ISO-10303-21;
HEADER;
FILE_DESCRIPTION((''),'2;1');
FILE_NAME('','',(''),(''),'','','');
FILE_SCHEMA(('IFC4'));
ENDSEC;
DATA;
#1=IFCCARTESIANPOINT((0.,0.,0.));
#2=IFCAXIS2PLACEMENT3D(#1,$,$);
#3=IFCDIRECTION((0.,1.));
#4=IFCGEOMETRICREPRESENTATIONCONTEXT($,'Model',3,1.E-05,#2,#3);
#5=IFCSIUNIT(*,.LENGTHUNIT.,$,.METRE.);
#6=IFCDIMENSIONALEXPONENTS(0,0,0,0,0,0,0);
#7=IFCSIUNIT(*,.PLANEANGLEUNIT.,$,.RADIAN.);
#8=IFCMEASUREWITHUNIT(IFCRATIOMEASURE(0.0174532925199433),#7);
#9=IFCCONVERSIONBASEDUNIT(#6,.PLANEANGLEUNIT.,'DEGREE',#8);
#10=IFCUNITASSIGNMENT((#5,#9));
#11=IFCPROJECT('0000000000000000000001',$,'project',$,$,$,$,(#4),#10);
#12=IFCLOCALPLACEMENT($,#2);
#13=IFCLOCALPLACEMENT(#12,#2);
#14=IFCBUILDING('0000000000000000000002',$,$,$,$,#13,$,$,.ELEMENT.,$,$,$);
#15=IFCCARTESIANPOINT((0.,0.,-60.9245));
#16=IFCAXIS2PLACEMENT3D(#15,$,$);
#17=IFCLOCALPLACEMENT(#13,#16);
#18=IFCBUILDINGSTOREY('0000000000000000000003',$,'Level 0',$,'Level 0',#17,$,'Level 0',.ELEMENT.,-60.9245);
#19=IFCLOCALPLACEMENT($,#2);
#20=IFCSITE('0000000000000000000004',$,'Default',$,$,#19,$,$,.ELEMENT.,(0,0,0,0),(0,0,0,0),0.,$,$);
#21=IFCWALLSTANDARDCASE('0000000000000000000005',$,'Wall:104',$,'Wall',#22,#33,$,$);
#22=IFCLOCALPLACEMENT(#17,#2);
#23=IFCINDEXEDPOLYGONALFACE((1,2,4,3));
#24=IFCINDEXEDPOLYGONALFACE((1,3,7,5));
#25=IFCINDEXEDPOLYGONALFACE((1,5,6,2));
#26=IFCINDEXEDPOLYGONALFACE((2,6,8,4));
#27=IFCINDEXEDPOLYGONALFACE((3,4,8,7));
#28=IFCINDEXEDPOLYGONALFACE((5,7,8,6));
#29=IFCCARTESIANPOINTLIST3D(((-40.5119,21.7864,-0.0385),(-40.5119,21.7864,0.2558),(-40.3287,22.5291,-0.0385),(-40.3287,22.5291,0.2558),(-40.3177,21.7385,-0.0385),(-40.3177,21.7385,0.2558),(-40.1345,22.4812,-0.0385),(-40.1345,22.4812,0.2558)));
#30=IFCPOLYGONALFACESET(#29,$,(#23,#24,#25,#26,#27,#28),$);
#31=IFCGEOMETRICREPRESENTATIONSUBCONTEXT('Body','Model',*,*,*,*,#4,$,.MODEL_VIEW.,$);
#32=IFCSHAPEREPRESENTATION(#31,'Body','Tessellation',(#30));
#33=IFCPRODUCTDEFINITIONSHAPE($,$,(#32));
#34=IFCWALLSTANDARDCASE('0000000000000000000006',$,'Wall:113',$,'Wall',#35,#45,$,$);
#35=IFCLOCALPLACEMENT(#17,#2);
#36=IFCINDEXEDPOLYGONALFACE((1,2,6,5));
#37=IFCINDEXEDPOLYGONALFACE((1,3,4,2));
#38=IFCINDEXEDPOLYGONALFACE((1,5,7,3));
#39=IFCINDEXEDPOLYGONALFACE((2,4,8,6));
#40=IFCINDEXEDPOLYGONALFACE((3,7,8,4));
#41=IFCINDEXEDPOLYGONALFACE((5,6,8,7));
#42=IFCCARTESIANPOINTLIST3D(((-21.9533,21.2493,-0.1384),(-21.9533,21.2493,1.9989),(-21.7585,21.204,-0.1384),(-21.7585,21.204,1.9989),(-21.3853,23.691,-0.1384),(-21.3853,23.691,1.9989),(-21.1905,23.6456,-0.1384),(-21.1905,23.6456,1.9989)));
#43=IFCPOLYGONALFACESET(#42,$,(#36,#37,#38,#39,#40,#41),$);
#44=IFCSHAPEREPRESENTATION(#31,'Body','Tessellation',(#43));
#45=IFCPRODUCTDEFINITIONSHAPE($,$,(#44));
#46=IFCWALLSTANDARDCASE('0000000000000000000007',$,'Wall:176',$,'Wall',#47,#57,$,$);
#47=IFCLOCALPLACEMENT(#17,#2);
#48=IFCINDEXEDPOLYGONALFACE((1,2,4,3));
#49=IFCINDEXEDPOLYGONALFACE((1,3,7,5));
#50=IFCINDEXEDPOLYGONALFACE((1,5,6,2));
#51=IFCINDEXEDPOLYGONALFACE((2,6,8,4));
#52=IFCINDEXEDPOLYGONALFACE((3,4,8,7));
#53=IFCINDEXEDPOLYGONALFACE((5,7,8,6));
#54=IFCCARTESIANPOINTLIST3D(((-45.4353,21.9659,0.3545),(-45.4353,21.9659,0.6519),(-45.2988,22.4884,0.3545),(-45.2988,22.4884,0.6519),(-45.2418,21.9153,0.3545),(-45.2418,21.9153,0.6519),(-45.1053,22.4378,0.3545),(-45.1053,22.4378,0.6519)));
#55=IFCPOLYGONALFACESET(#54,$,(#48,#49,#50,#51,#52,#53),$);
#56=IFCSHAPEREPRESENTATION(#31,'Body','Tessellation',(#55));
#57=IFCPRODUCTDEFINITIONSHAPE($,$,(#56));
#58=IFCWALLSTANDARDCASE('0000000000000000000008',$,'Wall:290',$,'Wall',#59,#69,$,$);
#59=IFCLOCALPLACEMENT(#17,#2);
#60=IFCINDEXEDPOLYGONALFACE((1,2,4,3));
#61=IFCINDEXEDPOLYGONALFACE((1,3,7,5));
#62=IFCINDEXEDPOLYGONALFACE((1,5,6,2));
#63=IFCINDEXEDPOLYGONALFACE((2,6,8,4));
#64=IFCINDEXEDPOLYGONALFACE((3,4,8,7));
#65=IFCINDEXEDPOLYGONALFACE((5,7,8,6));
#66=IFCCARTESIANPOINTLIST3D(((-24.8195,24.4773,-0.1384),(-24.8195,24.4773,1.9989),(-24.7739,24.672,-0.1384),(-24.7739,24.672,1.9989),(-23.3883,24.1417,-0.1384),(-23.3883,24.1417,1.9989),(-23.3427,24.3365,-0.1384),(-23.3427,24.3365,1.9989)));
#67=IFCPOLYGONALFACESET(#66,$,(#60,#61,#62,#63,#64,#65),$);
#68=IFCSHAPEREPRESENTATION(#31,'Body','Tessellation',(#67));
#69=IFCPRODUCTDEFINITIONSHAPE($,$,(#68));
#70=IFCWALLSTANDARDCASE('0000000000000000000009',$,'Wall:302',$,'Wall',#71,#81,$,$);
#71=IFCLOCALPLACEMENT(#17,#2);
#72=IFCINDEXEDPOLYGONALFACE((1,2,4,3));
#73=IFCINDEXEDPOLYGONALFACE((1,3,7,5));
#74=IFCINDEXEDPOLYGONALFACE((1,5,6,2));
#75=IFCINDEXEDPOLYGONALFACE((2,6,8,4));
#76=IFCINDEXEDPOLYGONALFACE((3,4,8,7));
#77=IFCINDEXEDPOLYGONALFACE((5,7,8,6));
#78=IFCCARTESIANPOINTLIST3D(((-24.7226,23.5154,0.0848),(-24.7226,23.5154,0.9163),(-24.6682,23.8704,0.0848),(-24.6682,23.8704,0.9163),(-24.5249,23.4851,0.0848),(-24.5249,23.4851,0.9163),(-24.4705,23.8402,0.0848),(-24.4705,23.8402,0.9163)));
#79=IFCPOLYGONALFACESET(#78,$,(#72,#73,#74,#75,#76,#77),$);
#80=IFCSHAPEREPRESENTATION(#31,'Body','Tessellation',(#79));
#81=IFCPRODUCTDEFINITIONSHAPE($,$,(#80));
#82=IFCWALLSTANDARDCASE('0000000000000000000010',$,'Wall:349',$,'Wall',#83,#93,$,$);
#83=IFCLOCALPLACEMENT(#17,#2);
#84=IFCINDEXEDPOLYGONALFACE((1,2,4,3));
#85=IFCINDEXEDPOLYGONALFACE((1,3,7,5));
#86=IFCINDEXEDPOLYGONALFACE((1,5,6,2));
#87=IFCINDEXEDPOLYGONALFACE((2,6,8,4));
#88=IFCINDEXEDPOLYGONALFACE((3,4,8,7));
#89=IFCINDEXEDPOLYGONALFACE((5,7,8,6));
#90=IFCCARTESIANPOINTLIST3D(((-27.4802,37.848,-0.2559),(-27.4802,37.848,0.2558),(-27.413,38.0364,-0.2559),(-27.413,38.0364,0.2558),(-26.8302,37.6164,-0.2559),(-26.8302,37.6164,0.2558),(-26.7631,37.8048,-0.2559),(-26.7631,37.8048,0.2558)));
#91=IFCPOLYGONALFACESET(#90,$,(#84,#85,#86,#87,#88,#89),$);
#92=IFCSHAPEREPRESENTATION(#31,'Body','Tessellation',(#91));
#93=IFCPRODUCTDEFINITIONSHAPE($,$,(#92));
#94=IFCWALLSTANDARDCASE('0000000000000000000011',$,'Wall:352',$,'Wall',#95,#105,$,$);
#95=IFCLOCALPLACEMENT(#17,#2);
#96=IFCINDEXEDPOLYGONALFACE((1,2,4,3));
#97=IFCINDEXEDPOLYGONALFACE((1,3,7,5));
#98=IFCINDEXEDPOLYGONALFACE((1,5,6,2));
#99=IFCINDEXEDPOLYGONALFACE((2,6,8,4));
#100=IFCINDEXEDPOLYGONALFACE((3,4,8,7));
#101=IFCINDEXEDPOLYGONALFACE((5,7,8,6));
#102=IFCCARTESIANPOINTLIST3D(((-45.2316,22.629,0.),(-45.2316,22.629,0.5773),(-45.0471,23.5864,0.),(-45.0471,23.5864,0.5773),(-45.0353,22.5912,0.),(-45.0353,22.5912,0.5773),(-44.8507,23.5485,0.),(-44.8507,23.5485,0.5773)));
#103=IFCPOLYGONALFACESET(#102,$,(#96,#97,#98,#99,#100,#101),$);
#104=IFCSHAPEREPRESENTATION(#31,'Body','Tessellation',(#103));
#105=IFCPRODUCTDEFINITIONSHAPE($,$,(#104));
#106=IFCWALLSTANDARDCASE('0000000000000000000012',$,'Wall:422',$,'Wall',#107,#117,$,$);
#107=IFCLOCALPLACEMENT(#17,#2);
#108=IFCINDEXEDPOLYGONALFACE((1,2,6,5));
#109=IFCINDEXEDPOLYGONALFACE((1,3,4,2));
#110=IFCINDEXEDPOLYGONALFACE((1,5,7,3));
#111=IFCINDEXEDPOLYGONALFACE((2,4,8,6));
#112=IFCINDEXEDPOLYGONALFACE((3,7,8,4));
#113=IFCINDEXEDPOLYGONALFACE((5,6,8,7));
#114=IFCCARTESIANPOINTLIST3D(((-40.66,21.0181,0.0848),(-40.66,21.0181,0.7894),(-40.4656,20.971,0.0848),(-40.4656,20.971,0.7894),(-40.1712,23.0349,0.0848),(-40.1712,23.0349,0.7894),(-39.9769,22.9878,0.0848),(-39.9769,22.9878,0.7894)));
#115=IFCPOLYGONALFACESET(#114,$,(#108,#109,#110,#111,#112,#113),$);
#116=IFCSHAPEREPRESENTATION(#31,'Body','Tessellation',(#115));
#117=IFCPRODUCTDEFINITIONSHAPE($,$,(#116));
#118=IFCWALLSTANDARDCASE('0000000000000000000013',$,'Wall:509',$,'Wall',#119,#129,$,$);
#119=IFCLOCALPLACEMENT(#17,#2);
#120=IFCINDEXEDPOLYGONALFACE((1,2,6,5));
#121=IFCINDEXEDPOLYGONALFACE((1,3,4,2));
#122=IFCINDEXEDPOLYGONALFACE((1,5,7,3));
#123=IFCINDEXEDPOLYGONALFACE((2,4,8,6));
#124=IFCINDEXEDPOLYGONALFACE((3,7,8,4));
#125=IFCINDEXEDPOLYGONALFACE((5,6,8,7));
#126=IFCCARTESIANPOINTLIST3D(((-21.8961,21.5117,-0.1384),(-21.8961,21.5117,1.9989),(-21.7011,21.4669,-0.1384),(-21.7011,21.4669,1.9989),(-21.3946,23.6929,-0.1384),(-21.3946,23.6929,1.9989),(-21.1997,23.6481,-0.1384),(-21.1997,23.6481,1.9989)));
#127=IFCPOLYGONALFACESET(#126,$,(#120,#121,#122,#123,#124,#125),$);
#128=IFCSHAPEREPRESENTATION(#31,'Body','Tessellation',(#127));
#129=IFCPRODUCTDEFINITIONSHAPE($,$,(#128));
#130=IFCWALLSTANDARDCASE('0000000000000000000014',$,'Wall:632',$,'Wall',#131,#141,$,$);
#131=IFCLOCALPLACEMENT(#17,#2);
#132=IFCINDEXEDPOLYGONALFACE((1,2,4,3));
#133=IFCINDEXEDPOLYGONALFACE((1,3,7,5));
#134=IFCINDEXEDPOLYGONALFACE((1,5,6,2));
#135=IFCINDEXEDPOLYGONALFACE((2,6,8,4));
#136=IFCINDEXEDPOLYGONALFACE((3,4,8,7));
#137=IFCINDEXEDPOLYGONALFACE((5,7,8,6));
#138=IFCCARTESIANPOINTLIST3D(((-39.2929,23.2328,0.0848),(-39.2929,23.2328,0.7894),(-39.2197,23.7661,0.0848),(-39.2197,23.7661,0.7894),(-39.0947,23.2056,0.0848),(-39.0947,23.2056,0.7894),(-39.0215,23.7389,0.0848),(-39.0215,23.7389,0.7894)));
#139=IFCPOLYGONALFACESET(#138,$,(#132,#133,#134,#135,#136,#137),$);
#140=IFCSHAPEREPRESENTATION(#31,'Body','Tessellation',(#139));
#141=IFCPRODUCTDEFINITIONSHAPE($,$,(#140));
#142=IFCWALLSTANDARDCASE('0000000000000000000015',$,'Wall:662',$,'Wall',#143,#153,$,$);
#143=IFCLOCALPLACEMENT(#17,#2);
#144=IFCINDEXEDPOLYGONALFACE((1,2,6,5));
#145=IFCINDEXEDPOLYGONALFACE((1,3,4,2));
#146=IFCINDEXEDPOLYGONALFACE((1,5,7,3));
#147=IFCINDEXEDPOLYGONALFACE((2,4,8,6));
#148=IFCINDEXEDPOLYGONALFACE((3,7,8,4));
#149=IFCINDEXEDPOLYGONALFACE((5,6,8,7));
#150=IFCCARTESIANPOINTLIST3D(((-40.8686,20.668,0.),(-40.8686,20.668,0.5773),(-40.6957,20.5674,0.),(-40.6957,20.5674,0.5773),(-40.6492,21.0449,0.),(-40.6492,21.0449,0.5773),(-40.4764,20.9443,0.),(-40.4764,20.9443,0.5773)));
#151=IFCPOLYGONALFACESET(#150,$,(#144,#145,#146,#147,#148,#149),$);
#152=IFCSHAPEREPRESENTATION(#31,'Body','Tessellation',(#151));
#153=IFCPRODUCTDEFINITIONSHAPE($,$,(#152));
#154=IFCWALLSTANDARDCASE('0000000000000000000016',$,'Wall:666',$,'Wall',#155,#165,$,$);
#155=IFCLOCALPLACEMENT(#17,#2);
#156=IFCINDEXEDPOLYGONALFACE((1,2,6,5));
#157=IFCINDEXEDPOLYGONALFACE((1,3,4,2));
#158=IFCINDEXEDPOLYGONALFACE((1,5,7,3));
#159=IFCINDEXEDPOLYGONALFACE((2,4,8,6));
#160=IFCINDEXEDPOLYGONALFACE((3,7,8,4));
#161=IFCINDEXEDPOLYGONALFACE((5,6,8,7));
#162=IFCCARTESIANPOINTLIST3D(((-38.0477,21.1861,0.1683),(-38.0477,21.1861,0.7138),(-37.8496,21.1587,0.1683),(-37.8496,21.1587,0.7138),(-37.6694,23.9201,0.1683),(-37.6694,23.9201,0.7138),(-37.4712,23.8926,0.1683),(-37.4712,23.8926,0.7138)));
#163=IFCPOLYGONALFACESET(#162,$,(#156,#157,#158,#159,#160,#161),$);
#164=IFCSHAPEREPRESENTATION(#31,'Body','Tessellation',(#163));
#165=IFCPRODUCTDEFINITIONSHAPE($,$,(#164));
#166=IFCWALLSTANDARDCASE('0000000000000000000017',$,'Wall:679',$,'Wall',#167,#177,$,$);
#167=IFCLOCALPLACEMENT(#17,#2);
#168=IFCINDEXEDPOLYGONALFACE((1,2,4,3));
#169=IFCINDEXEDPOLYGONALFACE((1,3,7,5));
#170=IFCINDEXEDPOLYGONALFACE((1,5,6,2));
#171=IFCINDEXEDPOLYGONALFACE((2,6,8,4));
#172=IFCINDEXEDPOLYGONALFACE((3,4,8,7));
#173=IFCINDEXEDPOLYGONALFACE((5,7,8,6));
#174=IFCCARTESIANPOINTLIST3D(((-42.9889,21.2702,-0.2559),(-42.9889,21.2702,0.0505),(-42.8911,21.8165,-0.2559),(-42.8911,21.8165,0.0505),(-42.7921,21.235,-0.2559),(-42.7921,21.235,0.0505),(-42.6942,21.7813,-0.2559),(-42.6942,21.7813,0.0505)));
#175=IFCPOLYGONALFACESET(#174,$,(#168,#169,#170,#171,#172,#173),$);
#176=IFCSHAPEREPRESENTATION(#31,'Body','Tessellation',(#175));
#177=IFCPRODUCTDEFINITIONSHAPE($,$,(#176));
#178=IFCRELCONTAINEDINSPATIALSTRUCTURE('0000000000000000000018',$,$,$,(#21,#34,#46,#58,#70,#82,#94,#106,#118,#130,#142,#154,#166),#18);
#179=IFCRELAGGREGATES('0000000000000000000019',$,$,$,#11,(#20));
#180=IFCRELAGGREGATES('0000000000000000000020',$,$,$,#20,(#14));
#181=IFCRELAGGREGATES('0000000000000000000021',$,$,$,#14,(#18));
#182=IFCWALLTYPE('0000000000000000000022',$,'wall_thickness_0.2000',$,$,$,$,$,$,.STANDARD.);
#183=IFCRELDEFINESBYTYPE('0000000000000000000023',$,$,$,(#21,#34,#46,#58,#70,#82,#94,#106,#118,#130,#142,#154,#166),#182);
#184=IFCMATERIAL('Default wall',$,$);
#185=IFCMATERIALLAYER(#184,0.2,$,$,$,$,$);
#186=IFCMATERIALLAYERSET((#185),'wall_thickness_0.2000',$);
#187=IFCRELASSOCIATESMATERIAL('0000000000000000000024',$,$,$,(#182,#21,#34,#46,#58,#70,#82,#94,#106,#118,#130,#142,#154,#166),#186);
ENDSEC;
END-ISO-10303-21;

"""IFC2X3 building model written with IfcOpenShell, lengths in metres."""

from ifc_helpers import new_model, entity, si_unit, converted_unit, direction, frame, origin, place, context, subcontext, project, spatial, polyline, outline, extrude, material, layer, layer_set, layer_usage, type_object, element, save


model = new_model("IFC2X3")

# Units and contexts
model_context = context("Model", 3, precision=1e-05, world=origin(), true_north=direction((0.0, 1.0)))
body_context = subcontext(model_context, "Body", "Model", "MODEL_VIEW")
ifc_project = project(units=[si_unit("LENGTHUNIT", "METRE"), converted_unit("PLANEANGLEUNIT", "DEGREE", entity("IfcRatioMeasure", 0.0174532925199433), si_unit("PLANEANGLEUNIT", "RADIAN"), dimensions=[0, 0, 0, 0, 0, 0, 0])], contexts=[model_context])

# Site, building, storey
site_placement = place(None, origin())
site = spatial("IfcSite", under=ifc_project, at=site_placement, Name="Default", CompositionType="ELEMENT", RefLatitude=(0, 0, 0, 0), RefLongitude=(0, 0, 0, 0), RefElevation=0.0)
placement_1 = place(None, origin())
building_placement = place(placement_1, origin())
building = spatial("IfcBuilding", under=site, at=building_placement, CompositionType="ELEMENT")
storey_placement = place(building_placement, frame((0.0, 0.0, -60.9245)))
storey = spatial("IfcBuildingStorey", under=building, at=storey_placement, Name="Level 0", ObjectType="Level 0", LongName="Level 0", CompositionType="ELEMENT", Elevation=-60.9245)

# Walls
ifc_material = material(Name="Default wall")
ifc_layer = layer(ifc_material, 0.2)
ifc_layer_set = layer_set([ifc_layer], Name="wall_thickness_0.2000")
ifc_layer_usage = layer_usage(ifc_layer_set, "AXIS2", "POSITIVE", -0.1)
wall_type = type_object("IfcWallType", Name="wall_thickness_0.2000", PredefinedType="STANDARD", material=ifc_layer_set)
placement_2 = place(building_placement, frame((0.0, 0.0, -60.963)))
wall_1_placement = place(placement_2, frame((-40.4148, 21.7624, 0.0), z_axis=(0.0, 0.0, 1.0), x_axis=(0.239508, 0.970894, 0.0)))
element("IfcWallStandardCase", 1, at=wall_1_placement, inside=storey, type_object=wall_type, material=ifc_layer_usage, Name="Wall:104", ObjectType="Wall", context=body_context, shape_type="SweptSolid", body=[
    extrude(outline(polyline([(0.765, -0.1), (0.765, 0.1), (0.0, 0.1), (0.0, -0.1), (0.765, -0.1)])), origin(), (0.0, 0.0, 1.0), 0.2943),
])
placement_3 = place(building_placement, frame((0.0, 0.0, -61.0629)))
wall_2_placement = place(placement_3, frame((-21.2879, 23.6683, 0.0), z_axis=(0.0, 0.0, 1.0), x_axis=(-0.226591, -0.97399, 0.0)))
element("IfcWallStandardCase", 2, at=wall_2_placement, inside=storey, type_object=wall_type, material=ifc_layer_usage, Name="Wall:113", ObjectType="Wall", context=body_context, shape_type="SweptSolid", body=[
    extrude(outline(polyline([(2.5069, -0.1), (2.5069, 0.1), (0.0, 0.1), (0.0, -0.1), (2.5069, -0.1)])), origin(), (0.0, 0.0, 1.0), 2.1372),
])
placement_4 = place(building_placement, frame((0.0, 0.0, -60.57)))
wall_3_placement = place(placement_4, frame((-45.3385, 21.9406, 0.0), z_axis=(0.0, 0.0, 1.0), x_axis=(0.252802, 0.967518, 0.0)))
element("IfcWallStandardCase", 3, at=wall_3_placement, inside=storey, type_object=wall_type, material=ifc_layer_usage, Name="Wall:176", ObjectType="Wall", context=body_context, shape_type="SweptSolid", body=[
    extrude(outline(polyline([(0.54, -0.1), (0.54, 0.1), (0.0, 0.1), (0.0, -0.1), (0.54, -0.1)])), origin(), (0.0, 0.0, 1.0), 0.2973),
])
placement_5 = place(building_placement, frame((0.0, 0.0, -61.0629)))
wall_4_placement = place(placement_5, frame((-23.3655, 24.2391, 0.0), z_axis=(0.0, 0.0, 1.0), x_axis=(-0.973602, 0.228252, 0.0)))
element("IfcWallStandardCase", 4, at=wall_4_placement, inside=storey, type_object=wall_type, material=ifc_layer_usage, Name="Wall:290", ObjectType="Wall", context=body_context, shape_type="SweptSolid", body=[
    extrude(outline(polyline([(1.47, -0.1), (1.47, 0.1), (0.0, 0.1), (0.0, -0.1), (1.47, -0.1)])), origin(), (0.0, 0.0, 1.0), 2.1372),
])
placement_6 = place(building_placement, frame((0.0, 0.0, -60.8397)))
wall_5_placement = place(placement_6, frame((-24.5694, 23.8553, 0.0), z_axis=(0.0, 0.0, 1.0), x_axis=(-0.151291, -0.988489, 0.0)))
element("IfcWallStandardCase", 5, at=wall_5_placement, inside=storey, type_object=wall_type, material=ifc_layer_usage, Name="Wall:302", ObjectType="Wall", context=body_context, shape_type="SweptSolid", body=[
    extrude(outline(polyline([(0.3592, -0.1), (0.3592, 0.1), (0.0, 0.1), (0.0, -0.1), (0.3592, -0.1)])), origin(), (0.0, 0.0, 1.0), 0.8315),
])
placement_7 = place(building_placement, frame((0.0, 0.0, -61.1804)))
wall_6_placement = place(placement_7, frame((-27.4466, 37.9422, 0.0), z_axis=(0.0, 0.0, 1.0), x_axis=(0.941944, -0.335771, 0.0)))
element("IfcWallStandardCase", 6, at=wall_6_placement, inside=storey, type_object=wall_type, material=ifc_layer_usage, Name="Wall:349", ObjectType="Wall", context=body_context, shape_type="SweptSolid", body=[
    extrude(outline(polyline([(0.69, -0.1), (0.69, 0.1), (0.0, 0.1), (0.0, -0.1), (0.69, -0.1)])), origin(), (0.0, 0.0, 1.0), 0.5117),
])
wall_7_placement = place(storey_placement, frame((-44.9489, 23.5675, 0.0), z_axis=(0.0, 0.0, 1.0), x_axis=(-0.189256, -0.981928, 0.0)))
element("IfcWallStandardCase", 7, at=wall_7_placement, inside=storey, type_object=wall_type, material=ifc_layer_usage, Name="Wall:352", ObjectType="Wall", context=body_context, shape_type="SweptSolid", body=[
    extrude(outline(polyline([(0.975, -0.1), (0.975, 0.1), (0.0, 0.1), (0.0, -0.1), (0.975, -0.1)])), origin(), (0.0, 0.0, 1.0), 0.5773),
])
placement_8 = place(building_placement, frame((0.0, 0.0, -60.8397)))
wall_8_placement = place(placement_8, frame((-40.5628, 20.9946, 0.0), z_axis=(0.0, 0.0, 1.0), x_axis=(0.235511, 0.971872, 0.0)))
element("IfcWallStandardCase", 8, at=wall_8_placement, inside=storey, type_object=wall_type, material=ifc_layer_usage, Name="Wall:422", ObjectType="Wall", context=body_context, shape_type="SweptSolid", body=[
    extrude(outline(polyline([(2.0752, -0.1), (2.0752, 0.1), (0.0, 0.1), (0.0, -0.1), (2.0752, -0.1)])), origin(), (0.0, 0.0, 1.0), 0.7047),
])
placement_9 = place(building_placement, frame((0.0, 0.0, -61.0629)))
wall_9_placement = place(placement_9, frame((-21.2972, 23.6705, 0.0), z_axis=(0.0, 0.0, 1.0), x_axis=(-0.224035, -0.974581, 0.0)))
element("IfcWallStandardCase", 9, at=wall_9_placement, inside=storey, type_object=wall_type, material=ifc_layer_usage, Name="Wall:509", ObjectType="Wall", context=body_context, shape_type="SweptSolid", body=[
    extrude(outline(polyline([(2.2381, -0.1), (2.2381, 0.1), (0.0, 0.1), (0.0, -0.1), (2.2381, -0.1)])), origin(), (0.0, 0.0, 1.0), 2.1372),
])
placement_10 = place(building_placement, frame((0.0, 0.0, -60.8397)))
wall_10_placement = place(placement_10, frame((-39.1206, 23.7525, 0.0), z_axis=(0.0, 0.0, 1.0), x_axis=(-0.135938, -0.990717, 0.0)))
element("IfcWallStandardCase", 10, at=wall_10_placement, inside=storey, type_object=wall_type, material=ifc_layer_usage, Name="Wall:632", ObjectType="Wall", context=body_context, shape_type="SweptSolid", body=[
    extrude(outline(polyline([(0.5383, -0.1), (0.5383, 0.1), (0.0, 0.1), (0.0, -0.1), (0.5383, -0.1)])), origin(), (0.0, 0.0, 1.0), 0.7047),
])
wall_11_placement = place(storey_placement, frame((-40.5628, 20.9946, 0.0), z_axis=(0.0, 0.0, 1.0), x_axis=(-0.50306, -0.864252, 0.0)))
element("IfcWallStandardCase", 11, at=wall_11_placement, inside=storey, type_object=wall_type, material=ifc_layer_usage, Name="Wall:662", ObjectType="Wall", context=body_context, shape_type="SweptSolid", body=[
    extrude(outline(polyline([(0.4361, -0.1), (0.4361, 0.1), (0.0, 0.1), (0.0, -0.1), (0.4361, -0.1)])), origin(), (0.0, 0.0, 1.0), 0.5773),
])
placement_11 = place(building_placement, frame((0.0, 0.0, -60.7562)))
wall_12_placement = place(placement_11, frame((-37.9487, 21.1724, 0.0), z_axis=(0.0, 0.0, 1.0), x_axis=(0.137091, 0.990558, 0.0)))
element("IfcWallStandardCase", 12, at=wall_12_placement, inside=storey, type_object=wall_type, material=ifc_layer_usage, Name="Wall:666", ObjectType="Wall", context=body_context, shape_type="SweptSolid", body=[
    extrude(outline(polyline([(2.76, -0.1), (2.76, 0.1), (0.0, 0.1), (0.0, -0.1), (2.76, -0.1)])), origin(), (0.0, 0.0, 1.0), 0.5454),
])
placement_12 = place(building_placement, frame((0.0, 0.0, -61.1804)))
wall_13_placement = place(placement_12, frame((-42.7926, 21.7989, 0.0), z_axis=(0.0, 0.0, 1.0), x_axis=(-0.176349, -0.984328, 0.0)))
element("IfcWallStandardCase", 13, at=wall_13_placement, inside=storey, type_object=wall_type, material=ifc_layer_usage, Name="Wall:679", ObjectType="Wall", context=body_context, shape_type="SweptSolid", body=[
    extrude(outline(polyline([(0.555, -0.1), (0.555, 0.1), (0.0, 0.1), (0.0, -0.1), (0.555, -0.1)])), origin(), (0.0, 0.0, 1.0), 0.3064),
])

save(model, "model.ifc")
